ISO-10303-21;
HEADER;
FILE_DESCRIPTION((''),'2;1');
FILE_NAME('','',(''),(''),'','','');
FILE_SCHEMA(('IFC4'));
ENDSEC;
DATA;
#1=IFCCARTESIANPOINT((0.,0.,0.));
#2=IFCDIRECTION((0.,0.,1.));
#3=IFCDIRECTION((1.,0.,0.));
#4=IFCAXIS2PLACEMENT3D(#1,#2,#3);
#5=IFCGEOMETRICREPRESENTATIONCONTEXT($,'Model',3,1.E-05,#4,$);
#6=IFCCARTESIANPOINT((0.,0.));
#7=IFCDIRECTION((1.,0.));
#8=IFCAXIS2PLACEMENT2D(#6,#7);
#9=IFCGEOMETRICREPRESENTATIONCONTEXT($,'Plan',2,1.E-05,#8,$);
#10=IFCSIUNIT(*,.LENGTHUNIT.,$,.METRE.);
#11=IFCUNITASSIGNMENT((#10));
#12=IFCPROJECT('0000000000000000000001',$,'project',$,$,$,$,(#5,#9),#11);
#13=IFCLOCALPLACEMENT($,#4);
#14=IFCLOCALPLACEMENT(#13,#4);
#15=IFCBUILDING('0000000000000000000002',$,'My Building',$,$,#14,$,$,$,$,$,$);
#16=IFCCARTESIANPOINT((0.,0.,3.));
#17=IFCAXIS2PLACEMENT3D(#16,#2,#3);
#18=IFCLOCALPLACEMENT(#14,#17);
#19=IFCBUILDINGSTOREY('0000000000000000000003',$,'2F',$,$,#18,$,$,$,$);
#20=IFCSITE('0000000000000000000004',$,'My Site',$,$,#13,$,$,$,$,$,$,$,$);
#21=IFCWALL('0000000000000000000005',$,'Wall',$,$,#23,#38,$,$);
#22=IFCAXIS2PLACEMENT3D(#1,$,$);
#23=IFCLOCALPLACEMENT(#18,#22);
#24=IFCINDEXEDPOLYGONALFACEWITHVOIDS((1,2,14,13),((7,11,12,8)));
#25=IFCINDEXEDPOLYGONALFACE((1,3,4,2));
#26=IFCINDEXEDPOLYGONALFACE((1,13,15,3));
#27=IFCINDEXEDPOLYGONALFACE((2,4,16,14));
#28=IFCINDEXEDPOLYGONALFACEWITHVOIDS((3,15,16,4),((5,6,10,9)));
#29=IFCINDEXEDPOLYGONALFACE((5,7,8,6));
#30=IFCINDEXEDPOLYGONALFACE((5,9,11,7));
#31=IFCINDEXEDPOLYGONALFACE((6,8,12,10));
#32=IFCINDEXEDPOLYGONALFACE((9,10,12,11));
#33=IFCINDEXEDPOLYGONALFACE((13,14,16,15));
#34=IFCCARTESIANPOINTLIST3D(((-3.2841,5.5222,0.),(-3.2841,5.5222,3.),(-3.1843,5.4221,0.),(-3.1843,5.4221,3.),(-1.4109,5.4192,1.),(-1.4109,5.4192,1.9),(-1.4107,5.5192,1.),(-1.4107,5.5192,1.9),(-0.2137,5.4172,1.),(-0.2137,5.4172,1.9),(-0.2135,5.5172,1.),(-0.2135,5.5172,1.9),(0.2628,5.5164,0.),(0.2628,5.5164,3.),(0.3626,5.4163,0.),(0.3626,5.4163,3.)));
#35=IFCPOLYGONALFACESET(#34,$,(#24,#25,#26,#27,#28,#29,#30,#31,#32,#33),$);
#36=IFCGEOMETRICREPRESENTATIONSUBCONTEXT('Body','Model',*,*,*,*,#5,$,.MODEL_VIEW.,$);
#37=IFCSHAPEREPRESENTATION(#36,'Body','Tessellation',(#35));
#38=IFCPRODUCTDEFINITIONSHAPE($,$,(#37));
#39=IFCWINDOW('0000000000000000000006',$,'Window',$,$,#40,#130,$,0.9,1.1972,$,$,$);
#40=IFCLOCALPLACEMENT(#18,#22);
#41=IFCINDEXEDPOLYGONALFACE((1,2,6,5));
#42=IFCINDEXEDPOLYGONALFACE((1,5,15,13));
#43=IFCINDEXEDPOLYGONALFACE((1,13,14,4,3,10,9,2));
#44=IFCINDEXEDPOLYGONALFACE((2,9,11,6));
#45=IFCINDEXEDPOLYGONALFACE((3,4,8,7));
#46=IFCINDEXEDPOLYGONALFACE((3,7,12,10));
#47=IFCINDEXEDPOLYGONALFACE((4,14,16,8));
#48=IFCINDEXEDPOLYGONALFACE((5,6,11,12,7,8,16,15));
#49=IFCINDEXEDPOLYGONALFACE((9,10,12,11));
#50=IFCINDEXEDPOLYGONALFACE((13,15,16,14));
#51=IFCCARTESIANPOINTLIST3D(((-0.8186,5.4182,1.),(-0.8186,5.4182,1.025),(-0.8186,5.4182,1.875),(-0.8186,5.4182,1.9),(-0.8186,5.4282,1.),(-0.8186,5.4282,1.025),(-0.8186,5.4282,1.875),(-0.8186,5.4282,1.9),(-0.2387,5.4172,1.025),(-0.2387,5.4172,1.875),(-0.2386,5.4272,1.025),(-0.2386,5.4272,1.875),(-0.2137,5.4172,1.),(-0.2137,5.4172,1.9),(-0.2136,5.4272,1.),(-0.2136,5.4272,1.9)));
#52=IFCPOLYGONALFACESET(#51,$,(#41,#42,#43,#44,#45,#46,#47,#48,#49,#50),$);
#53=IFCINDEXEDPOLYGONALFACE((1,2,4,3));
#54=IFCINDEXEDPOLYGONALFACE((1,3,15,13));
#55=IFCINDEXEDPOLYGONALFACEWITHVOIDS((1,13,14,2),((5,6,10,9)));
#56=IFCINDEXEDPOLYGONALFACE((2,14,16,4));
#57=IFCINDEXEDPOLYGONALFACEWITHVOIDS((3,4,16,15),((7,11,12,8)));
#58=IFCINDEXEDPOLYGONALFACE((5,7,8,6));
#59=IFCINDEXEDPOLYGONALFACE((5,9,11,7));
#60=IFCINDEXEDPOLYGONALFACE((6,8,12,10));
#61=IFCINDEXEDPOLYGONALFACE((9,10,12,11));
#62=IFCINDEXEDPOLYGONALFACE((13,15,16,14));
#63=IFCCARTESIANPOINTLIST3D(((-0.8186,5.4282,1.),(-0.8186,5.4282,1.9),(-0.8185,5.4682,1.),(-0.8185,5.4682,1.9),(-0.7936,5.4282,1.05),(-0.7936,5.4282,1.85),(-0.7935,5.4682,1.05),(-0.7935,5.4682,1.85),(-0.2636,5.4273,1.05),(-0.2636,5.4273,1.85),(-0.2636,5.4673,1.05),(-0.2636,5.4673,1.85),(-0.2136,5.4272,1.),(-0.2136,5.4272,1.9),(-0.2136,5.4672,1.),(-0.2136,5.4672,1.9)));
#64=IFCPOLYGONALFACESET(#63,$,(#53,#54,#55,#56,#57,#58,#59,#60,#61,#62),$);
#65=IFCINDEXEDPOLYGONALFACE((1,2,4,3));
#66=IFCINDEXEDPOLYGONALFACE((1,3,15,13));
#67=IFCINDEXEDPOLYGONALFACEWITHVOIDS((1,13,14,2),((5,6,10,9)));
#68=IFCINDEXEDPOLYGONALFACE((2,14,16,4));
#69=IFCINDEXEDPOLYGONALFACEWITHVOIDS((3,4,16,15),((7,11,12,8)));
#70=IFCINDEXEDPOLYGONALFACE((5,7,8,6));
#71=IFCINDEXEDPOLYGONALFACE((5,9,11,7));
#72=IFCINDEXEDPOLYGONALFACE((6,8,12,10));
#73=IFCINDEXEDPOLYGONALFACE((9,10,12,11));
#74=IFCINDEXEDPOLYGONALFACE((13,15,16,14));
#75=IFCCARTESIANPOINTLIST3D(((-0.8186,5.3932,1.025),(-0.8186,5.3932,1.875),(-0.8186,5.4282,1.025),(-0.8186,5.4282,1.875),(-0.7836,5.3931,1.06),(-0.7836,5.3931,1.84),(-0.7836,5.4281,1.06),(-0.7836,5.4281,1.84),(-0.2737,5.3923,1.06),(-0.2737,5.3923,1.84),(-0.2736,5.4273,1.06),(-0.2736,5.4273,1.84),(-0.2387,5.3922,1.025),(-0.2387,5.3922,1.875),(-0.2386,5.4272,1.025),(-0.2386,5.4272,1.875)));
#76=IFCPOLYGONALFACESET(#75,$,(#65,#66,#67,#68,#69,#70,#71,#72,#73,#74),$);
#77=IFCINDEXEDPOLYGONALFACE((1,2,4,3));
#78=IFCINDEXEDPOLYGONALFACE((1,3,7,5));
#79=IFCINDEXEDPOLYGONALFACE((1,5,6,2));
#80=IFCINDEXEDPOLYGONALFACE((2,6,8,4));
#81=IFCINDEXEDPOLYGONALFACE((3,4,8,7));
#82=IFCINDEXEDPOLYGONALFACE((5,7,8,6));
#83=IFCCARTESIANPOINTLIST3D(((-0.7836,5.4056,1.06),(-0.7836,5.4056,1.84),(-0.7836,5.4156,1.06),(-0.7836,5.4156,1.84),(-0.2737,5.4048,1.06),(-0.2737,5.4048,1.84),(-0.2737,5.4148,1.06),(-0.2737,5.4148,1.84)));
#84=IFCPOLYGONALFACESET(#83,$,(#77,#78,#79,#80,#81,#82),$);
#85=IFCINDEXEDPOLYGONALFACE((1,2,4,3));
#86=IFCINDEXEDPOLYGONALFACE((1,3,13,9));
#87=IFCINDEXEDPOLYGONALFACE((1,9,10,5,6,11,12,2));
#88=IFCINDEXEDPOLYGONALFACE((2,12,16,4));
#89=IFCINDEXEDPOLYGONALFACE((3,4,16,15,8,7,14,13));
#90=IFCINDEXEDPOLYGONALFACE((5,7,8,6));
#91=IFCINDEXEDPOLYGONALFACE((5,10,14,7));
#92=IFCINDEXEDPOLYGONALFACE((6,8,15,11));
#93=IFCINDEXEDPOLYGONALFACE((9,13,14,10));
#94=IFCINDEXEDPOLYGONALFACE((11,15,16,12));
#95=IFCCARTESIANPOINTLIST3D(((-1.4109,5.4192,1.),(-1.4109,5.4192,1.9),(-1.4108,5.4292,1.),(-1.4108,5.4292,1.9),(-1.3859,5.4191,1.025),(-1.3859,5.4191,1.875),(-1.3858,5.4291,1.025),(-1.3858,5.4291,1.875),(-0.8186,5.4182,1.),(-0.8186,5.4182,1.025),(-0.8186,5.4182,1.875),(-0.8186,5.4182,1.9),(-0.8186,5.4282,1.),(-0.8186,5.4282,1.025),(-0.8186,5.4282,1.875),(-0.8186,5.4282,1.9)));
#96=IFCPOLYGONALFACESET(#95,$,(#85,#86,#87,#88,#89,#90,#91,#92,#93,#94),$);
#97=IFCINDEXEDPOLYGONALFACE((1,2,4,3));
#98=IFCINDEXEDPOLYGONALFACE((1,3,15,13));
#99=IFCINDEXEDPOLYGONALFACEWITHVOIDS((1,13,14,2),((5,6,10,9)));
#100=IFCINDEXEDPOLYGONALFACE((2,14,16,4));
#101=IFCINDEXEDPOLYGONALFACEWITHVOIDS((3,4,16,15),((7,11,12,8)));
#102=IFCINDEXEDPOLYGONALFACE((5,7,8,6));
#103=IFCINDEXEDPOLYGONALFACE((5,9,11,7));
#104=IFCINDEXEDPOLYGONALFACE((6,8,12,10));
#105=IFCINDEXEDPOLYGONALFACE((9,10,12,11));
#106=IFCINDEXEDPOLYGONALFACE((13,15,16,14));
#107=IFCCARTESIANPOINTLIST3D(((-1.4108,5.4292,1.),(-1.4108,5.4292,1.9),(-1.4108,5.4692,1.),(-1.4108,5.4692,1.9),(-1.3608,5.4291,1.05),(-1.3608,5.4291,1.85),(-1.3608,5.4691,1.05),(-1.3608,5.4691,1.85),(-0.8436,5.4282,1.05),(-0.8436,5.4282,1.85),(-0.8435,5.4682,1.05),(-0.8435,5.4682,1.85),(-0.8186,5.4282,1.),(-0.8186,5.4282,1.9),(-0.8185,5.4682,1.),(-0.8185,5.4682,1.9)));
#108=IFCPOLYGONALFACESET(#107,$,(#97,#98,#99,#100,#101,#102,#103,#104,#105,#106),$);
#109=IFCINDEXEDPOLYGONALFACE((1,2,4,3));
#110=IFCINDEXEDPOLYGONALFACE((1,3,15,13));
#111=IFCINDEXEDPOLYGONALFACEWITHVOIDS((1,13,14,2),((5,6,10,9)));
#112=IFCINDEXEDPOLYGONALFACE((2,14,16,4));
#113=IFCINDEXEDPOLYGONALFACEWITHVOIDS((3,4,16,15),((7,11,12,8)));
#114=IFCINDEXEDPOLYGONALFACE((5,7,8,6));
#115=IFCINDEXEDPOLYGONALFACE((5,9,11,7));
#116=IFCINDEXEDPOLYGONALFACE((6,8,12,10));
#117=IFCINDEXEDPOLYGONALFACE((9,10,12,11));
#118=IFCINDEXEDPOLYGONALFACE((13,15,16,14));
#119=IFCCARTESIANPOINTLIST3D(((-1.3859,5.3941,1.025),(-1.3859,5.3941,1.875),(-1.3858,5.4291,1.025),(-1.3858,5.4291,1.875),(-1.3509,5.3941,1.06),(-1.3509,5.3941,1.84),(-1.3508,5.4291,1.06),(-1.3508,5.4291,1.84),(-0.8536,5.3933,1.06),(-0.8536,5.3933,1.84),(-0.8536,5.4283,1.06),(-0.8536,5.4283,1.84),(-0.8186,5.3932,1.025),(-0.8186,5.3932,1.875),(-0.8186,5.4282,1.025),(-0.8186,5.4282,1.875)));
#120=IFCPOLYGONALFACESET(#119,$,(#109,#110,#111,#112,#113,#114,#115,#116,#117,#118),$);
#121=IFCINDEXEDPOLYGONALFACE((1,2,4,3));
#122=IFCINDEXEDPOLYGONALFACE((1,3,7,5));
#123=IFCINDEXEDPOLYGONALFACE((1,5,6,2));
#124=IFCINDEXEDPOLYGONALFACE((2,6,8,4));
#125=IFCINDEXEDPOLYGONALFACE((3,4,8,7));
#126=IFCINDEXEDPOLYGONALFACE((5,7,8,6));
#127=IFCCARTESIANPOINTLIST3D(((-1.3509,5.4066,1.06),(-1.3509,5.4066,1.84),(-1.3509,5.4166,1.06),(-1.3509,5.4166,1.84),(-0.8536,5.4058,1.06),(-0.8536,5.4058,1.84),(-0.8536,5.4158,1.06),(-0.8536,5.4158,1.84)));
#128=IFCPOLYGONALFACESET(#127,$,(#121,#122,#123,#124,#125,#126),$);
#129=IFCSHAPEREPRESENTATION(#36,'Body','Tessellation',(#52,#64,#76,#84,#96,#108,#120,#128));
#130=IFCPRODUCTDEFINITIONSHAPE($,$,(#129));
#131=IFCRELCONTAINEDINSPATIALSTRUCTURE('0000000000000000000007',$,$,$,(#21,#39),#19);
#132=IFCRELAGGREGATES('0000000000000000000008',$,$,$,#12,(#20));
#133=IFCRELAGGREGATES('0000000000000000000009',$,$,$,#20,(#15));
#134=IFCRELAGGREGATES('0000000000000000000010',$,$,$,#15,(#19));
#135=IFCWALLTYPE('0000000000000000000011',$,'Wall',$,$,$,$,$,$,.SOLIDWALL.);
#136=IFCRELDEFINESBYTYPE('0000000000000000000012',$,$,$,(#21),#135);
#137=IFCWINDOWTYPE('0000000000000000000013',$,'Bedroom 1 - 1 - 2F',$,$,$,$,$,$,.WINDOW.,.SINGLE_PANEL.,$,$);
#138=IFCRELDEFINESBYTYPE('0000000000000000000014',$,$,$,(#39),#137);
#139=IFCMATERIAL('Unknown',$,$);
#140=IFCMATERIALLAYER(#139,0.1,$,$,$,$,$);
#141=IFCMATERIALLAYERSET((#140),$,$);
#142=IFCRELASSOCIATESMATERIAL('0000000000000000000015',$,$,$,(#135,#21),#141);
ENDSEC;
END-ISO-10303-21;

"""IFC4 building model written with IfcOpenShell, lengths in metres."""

from ifc_helpers import new_model, entity, si_unit, frame, origin_with_axes, origin_2d_with_axis, place, context, subcontext, project, spatial, line, indexed_curve, outline, extrude, shape, source, transform, mapped, material, layer, layer_set, layer_usage, type_object, type_shapes, element, fill, save


model = new_model("IFC4")

# Units and contexts
model_context = context("Model", 3, precision=1e-05, world=origin_with_axes())
plan_context = context("Plan", 2, precision=1e-05, world=origin_2d_with_axis())
body_context_1 = subcontext(model_context, "Body", "Model", "MODEL_VIEW")
body_context_2 = subcontext(plan_context, "Body", "Plan", "PLAN_VIEW")
ifc_project = project(units=[si_unit("LENGTHUNIT", "METRE")], contexts=[model_context, plan_context])

# Site, building, storey
site_placement = place(None, origin_with_axes())
site = spatial("IfcSite", under=ifc_project, at=site_placement, Name="My Site")
building_placement = place(site_placement, origin_with_axes())
building = spatial("IfcBuilding", under=site, at=building_placement, Name="My Building")
storey_placement = place(building_placement, frame((0.0, 0.0, 3.0), z_axis=(0.0, 0.0, 1.0), x_axis=(1.0, 0.0, 0.0)))
storey = spatial("IfcBuildingStorey", under=building, at=storey_placement, Name="2F")

# Shared definitions
ifc_material = material(Name="Unknown")

# Shared definitions
ifc_layer_1 = layer(ifc_material, 0.1)
ifc_layer_set_1 = layer_set([ifc_layer_1])
wall_type = type_object("IfcWallType", Name="Wall", PredefinedType="SOLIDWALL", material=ifc_layer_set_1)

# Wall, opening, window
ifc_layer_usage_1 = layer_usage(ifc_layer_set_1, "AXIS2", "POSITIVE", 0.0)
wall_1_placement = place(storey_placement, frame((0.2628, 5.5164, 0.0), z_axis=(0.0, 0.0, 1.0), x_axis=(-0.999999, 0.001638, 0.0)))
wall_1 = element("IfcWall", 1, at=wall_1_placement, inside=storey, type_object=wall_type, material=ifc_layer_usage_1, Name="Wall", context=body_context_1, shape_type="SweptSolid", body=[
    extrude(outline(indexed_curve([(0.0, 0.0), (-0.1, 0.1), (3.4469, 0.1), (3.5469, 0.0)], segments=[line(1, 2, 3, 4, 1)])), origin_with_axes(), (0.0, 0.0, 1.0), 3.0),
])
shared_shape_1 = source(origin_with_axes(), body_context_1, "Body", "SweptSolid", [
    extrude(outline(indexed_curve([(0.0, 0.0), (1.1972, 0.0), (1.1972, 0.9), (0.0, 0.9)], segments=[line(1, 2, 3, 4, 1)])), frame((0.0, -0.6, 0.0), z_axis=(0.0, -1.0, 0.0), x_axis=(1.0, 0.0, 0.0)), (0.0, 0.0, -1.0), 1.2),
])
opening_1_placement = place(wall_1_placement, frame((0.4762, 0.0, 1.0), z_axis=(0.0, 0.0, 1.0), x_axis=(1.0, 0.0, 0.0)))
opening_1 = element("IfcOpeningElement", 2, at=opening_1_placement, cuts=wall_1, PredefinedType="OPENING", context=body_context_1, shape_type="MappedRepresentation", body=[
    mapped(shared_shape_1, transform((0.0, 0.0, 0.0), x_axis=(1.0, 0.0, 0.0), y_axis=(0.0, 1.0, 0.0), z_axis=(0.0, 0.0, 1.0), scale=1.0)),
])
window_type_1 = type_object("IfcWindowType", Name="Bedroom 1 - 1 - 2F", PartitioningType="SINGLE_PANEL", PredefinedType="WINDOW")
shared_shape_2 = source(origin_with_axes(), body_context_1, "Body", "SweptSolid", [
    extrude(outline(indexed_curve([(0.605, 0.0), (0.0, 0.0), (0.0, 0.9), (0.605, 0.9), (0.605, 0.875), (0.025, 0.875), (0.025, 0.025), (0.605, 0.025)], segments=[line(1, 2, 3, 4, 5, 6, 7, 8, 1)])), frame((0.0, 0.09, 0.0), z_axis=(0.0, -1.0, 0.0), x_axis=(1.0, 0.0, 0.0)), (0.0, 0.0, -1.0), 0.01),
    extrude(outline(indexed_curve([(0.0, 0.0), (0.605, 0.0), (0.605, 0.9), (0.0, 0.9)], segments=[line(1, 2, 3, 4, 1)]), holes=[indexed_curve([(0.05, 0.05), (0.58, 0.05), (0.58, 0.85), (0.05, 0.85)], segments=[line(1, 2, 3, 4, 1)])]), frame((0.0, 0.05, 0.0), z_axis=(0.0, -1.0, 0.0), x_axis=(1.0, 0.0, 0.0)), (0.0, 0.0, -1.0), 0.04),
    extrude(outline(indexed_curve([(0.0, 0.0), (0.58, 0.0), (0.58, 0.85), (0.0, 0.85)], segments=[line(1, 2, 3, 4, 1)]), holes=[indexed_curve([(0.035, 0.035), (0.545, 0.035), (0.545, 0.815), (0.035, 0.815)], segments=[line(1, 2, 3, 4, 1)])]), frame((0.025, 0.09, 0.025), z_axis=(0.0, -1.0, 0.0), x_axis=(1.0, 0.0, 0.0)), (0.0, 0.0, -1.0), 0.035),
    extrude(outline(indexed_curve([(0.035, 0.035), (0.545, 0.035), (0.545, 0.815), (0.035, 0.815)], segments=[line(1, 2, 3, 4, 1)])), frame((0.025, 0.1025, 0.025), z_axis=(0.0, -1.0, 0.0), x_axis=(1.0, 0.0, 0.0)), (0.0, 0.0, -1.0), 0.01),
    extrude(outline(indexed_curve([(0.0, 0.9), (0.5922, 0.9), (0.5922, 0.0), (0.0, 0.0), (0.0, 0.025), (0.5672, 0.025), (0.5672, 0.875), (0.0, 0.875)], segments=[line(1, 2, 3, 4, 5, 6, 7, 8, 1)])), frame((0.605, 0.09, 0.0), z_axis=(0.0, -1.0, 0.0), x_axis=(1.0, 0.0, 0.0)), (0.0, 0.0, -1.0), 0.01),
    extrude(outline(indexed_curve([(0.0, 0.0), (0.5922, 0.0), (0.5922, 0.9), (0.0, 0.9)], segments=[line(1, 2, 3, 4, 1)]), holes=[indexed_curve([(0.025, 0.05), (0.5422, 0.05), (0.5422, 0.85), (0.025, 0.85)], segments=[line(1, 2, 3, 4, 1)])]), frame((0.605, 0.05, 0.0), z_axis=(0.0, -1.0, 0.0), x_axis=(1.0, 0.0, 0.0)), (0.0, 0.0, -1.0), 0.04),
    extrude(outline(indexed_curve([(0.0, 0.0), (0.5672, 0.0), (0.5672, 0.85), (0.0, 0.85)], segments=[line(1, 2, 3, 4, 1)]), holes=[indexed_curve([(0.035, 0.035), (0.5322, 0.035), (0.5322, 0.815), (0.035, 0.815)], segments=[line(1, 2, 3, 4, 1)])]), frame((0.605, 0.09, 0.025), z_axis=(0.0, -1.0, 0.0), x_axis=(1.0, 0.0, 0.0)), (0.0, 0.0, -1.0), 0.035),
    extrude(outline(indexed_curve([(0.035, 0.035), (0.5322, 0.035), (0.5322, 0.815), (0.035, 0.815)], segments=[line(1, 2, 3, 4, 1)])), frame((0.605, 0.1025, 0.025), z_axis=(0.0, -1.0, 0.0), x_axis=(1.0, 0.0, 0.0)), (0.0, 0.0, -1.0), 0.01),
])
shared_shape_3 = source(origin_with_axes(), body_context_2, "Body", "Curve2D", [
    entity("IfcIndexedPolyCurve", entity("IfcCartesianPointList2D", [[0.05, 0.05], [0.58, 0.05]])),
    entity("IfcIndexedPolyCurve", entity("IfcCartesianPointList2D", [[0.0, 0.1], [0.025, 0.1], [0.025, 0.09], [0.05, 0.09], [0.05, 0.05], [0.0, 0.05]]), [entity("IfcLineIndex", [1, 2, 3, 4, 5, 6, 1])]),
    entity("IfcIndexedPolyCurve", entity("IfcCartesianPointList2D", [[0.605, 0.1], [0.605, 0.1], [0.605, 0.09], [0.58, 0.09], [0.58, 0.05], [0.605, 0.05]])),
    entity("IfcIndexedPolyCurve", entity("IfcCartesianPointList2D", [[0.025, 0.09], [0.06, 0.09], [0.06, 0.125], [0.025, 0.125]]), [entity("IfcLineIndex", [1, 2, 3, 4, 1])]),
    entity("IfcIndexedPolyCurve", entity("IfcCartesianPointList2D", [[0.605, 0.09], [0.57, 0.09], [0.57, 0.125], [0.605, 0.125]]), [entity("IfcLineIndex", [1, 2, 3, 4, 1])]),
    entity("IfcIndexedPolyCurve", entity("IfcCartesianPointList2D", [[0.06, 0.09], [0.57, 0.09]])),
    entity("IfcIndexedPolyCurve", entity("IfcCartesianPointList2D", [[0.06, 0.125], [0.57, 0.125]])),
    entity("IfcIndexedPolyCurve", entity("IfcCartesianPointList2D", [[0.06, 0.1075], [0.57, 0.1075]])),
    entity("IfcIndexedPolyCurve", entity("IfcCartesianPointList2D", [[0.63, 0.05], [1.1472, 0.05]])),
    entity("IfcIndexedPolyCurve", entity("IfcCartesianPointList2D", [[0.605, 0.1], [0.605, 0.1], [0.605, 0.09], [0.63, 0.09], [0.63, 0.05], [0.605, 0.05]])),
    entity("IfcIndexedPolyCurve", entity("IfcCartesianPointList2D", [[1.1972, 0.1], [1.1722, 0.1], [1.1722, 0.09], [1.1472, 0.09], [1.1472, 0.05], [1.1972, 0.05]]), [entity("IfcLineIndex", [1, 2, 3, 4, 5, 6, 1])]),
    entity("IfcIndexedPolyCurve", entity("IfcCartesianPointList2D", [[0.605, 0.09], [0.64, 0.09], [0.64, 0.125], [0.605, 0.125]]), [entity("IfcLineIndex", [1, 2, 3, 4, 1])]),
    entity("IfcIndexedPolyCurve", entity("IfcCartesianPointList2D", [[1.1722, 0.09], [1.1372, 0.09], [1.1372, 0.125], [1.1722, 0.125]]), [entity("IfcLineIndex", [1, 2, 3, 4, 1])]),
    entity("IfcIndexedPolyCurve", entity("IfcCartesianPointList2D", [[0.64, 0.09], [1.1372, 0.09]])),
    entity("IfcIndexedPolyCurve", entity("IfcCartesianPointList2D", [[0.64, 0.125], [1.1372, 0.125]])),
    entity("IfcIndexedPolyCurve", entity("IfcCartesianPointList2D", [[0.64, 0.1075], [1.1372, 0.1075]])),
])
type_shapes(window_type_1, [shared_shape_2, shared_shape_3])
window_1_placement = place(opening_1_placement, frame((0.0, 0.0, 0.0), z_axis=(0.0, 0.0, 1.0), x_axis=(1.0, 0.0, 0.0)))
window_1 = element("IfcWindow", 3, at=window_1_placement, inside=storey, type_object=window_type_1, Name="Window", OverallHeight=0.9, OverallWidth=1.1972, shapes=[
    shape(body_context_1, "Body", "MappedRepresentation", [mapped(shared_shape_2, transform((0.0, 0.0, 0.0), x_axis=(1.0, 0.0, 0.0), y_axis=(0.0, 1.0, 0.0), z_axis=(0.0, 0.0, 1.0), scale=1.0))]),
    shape(body_context_2, "Body", "MappedRepresentation", [mapped(shared_shape_3, transform((0.0, 0.0, 0.0), x_axis=(1.0, 0.0, 0.0), y_axis=(0.0, 1.0, 0.0), z_axis=(0.0, 0.0, 1.0), scale=1.0))]),
])
fill(opening_1, window_1)

save(model, "model.ifc")
